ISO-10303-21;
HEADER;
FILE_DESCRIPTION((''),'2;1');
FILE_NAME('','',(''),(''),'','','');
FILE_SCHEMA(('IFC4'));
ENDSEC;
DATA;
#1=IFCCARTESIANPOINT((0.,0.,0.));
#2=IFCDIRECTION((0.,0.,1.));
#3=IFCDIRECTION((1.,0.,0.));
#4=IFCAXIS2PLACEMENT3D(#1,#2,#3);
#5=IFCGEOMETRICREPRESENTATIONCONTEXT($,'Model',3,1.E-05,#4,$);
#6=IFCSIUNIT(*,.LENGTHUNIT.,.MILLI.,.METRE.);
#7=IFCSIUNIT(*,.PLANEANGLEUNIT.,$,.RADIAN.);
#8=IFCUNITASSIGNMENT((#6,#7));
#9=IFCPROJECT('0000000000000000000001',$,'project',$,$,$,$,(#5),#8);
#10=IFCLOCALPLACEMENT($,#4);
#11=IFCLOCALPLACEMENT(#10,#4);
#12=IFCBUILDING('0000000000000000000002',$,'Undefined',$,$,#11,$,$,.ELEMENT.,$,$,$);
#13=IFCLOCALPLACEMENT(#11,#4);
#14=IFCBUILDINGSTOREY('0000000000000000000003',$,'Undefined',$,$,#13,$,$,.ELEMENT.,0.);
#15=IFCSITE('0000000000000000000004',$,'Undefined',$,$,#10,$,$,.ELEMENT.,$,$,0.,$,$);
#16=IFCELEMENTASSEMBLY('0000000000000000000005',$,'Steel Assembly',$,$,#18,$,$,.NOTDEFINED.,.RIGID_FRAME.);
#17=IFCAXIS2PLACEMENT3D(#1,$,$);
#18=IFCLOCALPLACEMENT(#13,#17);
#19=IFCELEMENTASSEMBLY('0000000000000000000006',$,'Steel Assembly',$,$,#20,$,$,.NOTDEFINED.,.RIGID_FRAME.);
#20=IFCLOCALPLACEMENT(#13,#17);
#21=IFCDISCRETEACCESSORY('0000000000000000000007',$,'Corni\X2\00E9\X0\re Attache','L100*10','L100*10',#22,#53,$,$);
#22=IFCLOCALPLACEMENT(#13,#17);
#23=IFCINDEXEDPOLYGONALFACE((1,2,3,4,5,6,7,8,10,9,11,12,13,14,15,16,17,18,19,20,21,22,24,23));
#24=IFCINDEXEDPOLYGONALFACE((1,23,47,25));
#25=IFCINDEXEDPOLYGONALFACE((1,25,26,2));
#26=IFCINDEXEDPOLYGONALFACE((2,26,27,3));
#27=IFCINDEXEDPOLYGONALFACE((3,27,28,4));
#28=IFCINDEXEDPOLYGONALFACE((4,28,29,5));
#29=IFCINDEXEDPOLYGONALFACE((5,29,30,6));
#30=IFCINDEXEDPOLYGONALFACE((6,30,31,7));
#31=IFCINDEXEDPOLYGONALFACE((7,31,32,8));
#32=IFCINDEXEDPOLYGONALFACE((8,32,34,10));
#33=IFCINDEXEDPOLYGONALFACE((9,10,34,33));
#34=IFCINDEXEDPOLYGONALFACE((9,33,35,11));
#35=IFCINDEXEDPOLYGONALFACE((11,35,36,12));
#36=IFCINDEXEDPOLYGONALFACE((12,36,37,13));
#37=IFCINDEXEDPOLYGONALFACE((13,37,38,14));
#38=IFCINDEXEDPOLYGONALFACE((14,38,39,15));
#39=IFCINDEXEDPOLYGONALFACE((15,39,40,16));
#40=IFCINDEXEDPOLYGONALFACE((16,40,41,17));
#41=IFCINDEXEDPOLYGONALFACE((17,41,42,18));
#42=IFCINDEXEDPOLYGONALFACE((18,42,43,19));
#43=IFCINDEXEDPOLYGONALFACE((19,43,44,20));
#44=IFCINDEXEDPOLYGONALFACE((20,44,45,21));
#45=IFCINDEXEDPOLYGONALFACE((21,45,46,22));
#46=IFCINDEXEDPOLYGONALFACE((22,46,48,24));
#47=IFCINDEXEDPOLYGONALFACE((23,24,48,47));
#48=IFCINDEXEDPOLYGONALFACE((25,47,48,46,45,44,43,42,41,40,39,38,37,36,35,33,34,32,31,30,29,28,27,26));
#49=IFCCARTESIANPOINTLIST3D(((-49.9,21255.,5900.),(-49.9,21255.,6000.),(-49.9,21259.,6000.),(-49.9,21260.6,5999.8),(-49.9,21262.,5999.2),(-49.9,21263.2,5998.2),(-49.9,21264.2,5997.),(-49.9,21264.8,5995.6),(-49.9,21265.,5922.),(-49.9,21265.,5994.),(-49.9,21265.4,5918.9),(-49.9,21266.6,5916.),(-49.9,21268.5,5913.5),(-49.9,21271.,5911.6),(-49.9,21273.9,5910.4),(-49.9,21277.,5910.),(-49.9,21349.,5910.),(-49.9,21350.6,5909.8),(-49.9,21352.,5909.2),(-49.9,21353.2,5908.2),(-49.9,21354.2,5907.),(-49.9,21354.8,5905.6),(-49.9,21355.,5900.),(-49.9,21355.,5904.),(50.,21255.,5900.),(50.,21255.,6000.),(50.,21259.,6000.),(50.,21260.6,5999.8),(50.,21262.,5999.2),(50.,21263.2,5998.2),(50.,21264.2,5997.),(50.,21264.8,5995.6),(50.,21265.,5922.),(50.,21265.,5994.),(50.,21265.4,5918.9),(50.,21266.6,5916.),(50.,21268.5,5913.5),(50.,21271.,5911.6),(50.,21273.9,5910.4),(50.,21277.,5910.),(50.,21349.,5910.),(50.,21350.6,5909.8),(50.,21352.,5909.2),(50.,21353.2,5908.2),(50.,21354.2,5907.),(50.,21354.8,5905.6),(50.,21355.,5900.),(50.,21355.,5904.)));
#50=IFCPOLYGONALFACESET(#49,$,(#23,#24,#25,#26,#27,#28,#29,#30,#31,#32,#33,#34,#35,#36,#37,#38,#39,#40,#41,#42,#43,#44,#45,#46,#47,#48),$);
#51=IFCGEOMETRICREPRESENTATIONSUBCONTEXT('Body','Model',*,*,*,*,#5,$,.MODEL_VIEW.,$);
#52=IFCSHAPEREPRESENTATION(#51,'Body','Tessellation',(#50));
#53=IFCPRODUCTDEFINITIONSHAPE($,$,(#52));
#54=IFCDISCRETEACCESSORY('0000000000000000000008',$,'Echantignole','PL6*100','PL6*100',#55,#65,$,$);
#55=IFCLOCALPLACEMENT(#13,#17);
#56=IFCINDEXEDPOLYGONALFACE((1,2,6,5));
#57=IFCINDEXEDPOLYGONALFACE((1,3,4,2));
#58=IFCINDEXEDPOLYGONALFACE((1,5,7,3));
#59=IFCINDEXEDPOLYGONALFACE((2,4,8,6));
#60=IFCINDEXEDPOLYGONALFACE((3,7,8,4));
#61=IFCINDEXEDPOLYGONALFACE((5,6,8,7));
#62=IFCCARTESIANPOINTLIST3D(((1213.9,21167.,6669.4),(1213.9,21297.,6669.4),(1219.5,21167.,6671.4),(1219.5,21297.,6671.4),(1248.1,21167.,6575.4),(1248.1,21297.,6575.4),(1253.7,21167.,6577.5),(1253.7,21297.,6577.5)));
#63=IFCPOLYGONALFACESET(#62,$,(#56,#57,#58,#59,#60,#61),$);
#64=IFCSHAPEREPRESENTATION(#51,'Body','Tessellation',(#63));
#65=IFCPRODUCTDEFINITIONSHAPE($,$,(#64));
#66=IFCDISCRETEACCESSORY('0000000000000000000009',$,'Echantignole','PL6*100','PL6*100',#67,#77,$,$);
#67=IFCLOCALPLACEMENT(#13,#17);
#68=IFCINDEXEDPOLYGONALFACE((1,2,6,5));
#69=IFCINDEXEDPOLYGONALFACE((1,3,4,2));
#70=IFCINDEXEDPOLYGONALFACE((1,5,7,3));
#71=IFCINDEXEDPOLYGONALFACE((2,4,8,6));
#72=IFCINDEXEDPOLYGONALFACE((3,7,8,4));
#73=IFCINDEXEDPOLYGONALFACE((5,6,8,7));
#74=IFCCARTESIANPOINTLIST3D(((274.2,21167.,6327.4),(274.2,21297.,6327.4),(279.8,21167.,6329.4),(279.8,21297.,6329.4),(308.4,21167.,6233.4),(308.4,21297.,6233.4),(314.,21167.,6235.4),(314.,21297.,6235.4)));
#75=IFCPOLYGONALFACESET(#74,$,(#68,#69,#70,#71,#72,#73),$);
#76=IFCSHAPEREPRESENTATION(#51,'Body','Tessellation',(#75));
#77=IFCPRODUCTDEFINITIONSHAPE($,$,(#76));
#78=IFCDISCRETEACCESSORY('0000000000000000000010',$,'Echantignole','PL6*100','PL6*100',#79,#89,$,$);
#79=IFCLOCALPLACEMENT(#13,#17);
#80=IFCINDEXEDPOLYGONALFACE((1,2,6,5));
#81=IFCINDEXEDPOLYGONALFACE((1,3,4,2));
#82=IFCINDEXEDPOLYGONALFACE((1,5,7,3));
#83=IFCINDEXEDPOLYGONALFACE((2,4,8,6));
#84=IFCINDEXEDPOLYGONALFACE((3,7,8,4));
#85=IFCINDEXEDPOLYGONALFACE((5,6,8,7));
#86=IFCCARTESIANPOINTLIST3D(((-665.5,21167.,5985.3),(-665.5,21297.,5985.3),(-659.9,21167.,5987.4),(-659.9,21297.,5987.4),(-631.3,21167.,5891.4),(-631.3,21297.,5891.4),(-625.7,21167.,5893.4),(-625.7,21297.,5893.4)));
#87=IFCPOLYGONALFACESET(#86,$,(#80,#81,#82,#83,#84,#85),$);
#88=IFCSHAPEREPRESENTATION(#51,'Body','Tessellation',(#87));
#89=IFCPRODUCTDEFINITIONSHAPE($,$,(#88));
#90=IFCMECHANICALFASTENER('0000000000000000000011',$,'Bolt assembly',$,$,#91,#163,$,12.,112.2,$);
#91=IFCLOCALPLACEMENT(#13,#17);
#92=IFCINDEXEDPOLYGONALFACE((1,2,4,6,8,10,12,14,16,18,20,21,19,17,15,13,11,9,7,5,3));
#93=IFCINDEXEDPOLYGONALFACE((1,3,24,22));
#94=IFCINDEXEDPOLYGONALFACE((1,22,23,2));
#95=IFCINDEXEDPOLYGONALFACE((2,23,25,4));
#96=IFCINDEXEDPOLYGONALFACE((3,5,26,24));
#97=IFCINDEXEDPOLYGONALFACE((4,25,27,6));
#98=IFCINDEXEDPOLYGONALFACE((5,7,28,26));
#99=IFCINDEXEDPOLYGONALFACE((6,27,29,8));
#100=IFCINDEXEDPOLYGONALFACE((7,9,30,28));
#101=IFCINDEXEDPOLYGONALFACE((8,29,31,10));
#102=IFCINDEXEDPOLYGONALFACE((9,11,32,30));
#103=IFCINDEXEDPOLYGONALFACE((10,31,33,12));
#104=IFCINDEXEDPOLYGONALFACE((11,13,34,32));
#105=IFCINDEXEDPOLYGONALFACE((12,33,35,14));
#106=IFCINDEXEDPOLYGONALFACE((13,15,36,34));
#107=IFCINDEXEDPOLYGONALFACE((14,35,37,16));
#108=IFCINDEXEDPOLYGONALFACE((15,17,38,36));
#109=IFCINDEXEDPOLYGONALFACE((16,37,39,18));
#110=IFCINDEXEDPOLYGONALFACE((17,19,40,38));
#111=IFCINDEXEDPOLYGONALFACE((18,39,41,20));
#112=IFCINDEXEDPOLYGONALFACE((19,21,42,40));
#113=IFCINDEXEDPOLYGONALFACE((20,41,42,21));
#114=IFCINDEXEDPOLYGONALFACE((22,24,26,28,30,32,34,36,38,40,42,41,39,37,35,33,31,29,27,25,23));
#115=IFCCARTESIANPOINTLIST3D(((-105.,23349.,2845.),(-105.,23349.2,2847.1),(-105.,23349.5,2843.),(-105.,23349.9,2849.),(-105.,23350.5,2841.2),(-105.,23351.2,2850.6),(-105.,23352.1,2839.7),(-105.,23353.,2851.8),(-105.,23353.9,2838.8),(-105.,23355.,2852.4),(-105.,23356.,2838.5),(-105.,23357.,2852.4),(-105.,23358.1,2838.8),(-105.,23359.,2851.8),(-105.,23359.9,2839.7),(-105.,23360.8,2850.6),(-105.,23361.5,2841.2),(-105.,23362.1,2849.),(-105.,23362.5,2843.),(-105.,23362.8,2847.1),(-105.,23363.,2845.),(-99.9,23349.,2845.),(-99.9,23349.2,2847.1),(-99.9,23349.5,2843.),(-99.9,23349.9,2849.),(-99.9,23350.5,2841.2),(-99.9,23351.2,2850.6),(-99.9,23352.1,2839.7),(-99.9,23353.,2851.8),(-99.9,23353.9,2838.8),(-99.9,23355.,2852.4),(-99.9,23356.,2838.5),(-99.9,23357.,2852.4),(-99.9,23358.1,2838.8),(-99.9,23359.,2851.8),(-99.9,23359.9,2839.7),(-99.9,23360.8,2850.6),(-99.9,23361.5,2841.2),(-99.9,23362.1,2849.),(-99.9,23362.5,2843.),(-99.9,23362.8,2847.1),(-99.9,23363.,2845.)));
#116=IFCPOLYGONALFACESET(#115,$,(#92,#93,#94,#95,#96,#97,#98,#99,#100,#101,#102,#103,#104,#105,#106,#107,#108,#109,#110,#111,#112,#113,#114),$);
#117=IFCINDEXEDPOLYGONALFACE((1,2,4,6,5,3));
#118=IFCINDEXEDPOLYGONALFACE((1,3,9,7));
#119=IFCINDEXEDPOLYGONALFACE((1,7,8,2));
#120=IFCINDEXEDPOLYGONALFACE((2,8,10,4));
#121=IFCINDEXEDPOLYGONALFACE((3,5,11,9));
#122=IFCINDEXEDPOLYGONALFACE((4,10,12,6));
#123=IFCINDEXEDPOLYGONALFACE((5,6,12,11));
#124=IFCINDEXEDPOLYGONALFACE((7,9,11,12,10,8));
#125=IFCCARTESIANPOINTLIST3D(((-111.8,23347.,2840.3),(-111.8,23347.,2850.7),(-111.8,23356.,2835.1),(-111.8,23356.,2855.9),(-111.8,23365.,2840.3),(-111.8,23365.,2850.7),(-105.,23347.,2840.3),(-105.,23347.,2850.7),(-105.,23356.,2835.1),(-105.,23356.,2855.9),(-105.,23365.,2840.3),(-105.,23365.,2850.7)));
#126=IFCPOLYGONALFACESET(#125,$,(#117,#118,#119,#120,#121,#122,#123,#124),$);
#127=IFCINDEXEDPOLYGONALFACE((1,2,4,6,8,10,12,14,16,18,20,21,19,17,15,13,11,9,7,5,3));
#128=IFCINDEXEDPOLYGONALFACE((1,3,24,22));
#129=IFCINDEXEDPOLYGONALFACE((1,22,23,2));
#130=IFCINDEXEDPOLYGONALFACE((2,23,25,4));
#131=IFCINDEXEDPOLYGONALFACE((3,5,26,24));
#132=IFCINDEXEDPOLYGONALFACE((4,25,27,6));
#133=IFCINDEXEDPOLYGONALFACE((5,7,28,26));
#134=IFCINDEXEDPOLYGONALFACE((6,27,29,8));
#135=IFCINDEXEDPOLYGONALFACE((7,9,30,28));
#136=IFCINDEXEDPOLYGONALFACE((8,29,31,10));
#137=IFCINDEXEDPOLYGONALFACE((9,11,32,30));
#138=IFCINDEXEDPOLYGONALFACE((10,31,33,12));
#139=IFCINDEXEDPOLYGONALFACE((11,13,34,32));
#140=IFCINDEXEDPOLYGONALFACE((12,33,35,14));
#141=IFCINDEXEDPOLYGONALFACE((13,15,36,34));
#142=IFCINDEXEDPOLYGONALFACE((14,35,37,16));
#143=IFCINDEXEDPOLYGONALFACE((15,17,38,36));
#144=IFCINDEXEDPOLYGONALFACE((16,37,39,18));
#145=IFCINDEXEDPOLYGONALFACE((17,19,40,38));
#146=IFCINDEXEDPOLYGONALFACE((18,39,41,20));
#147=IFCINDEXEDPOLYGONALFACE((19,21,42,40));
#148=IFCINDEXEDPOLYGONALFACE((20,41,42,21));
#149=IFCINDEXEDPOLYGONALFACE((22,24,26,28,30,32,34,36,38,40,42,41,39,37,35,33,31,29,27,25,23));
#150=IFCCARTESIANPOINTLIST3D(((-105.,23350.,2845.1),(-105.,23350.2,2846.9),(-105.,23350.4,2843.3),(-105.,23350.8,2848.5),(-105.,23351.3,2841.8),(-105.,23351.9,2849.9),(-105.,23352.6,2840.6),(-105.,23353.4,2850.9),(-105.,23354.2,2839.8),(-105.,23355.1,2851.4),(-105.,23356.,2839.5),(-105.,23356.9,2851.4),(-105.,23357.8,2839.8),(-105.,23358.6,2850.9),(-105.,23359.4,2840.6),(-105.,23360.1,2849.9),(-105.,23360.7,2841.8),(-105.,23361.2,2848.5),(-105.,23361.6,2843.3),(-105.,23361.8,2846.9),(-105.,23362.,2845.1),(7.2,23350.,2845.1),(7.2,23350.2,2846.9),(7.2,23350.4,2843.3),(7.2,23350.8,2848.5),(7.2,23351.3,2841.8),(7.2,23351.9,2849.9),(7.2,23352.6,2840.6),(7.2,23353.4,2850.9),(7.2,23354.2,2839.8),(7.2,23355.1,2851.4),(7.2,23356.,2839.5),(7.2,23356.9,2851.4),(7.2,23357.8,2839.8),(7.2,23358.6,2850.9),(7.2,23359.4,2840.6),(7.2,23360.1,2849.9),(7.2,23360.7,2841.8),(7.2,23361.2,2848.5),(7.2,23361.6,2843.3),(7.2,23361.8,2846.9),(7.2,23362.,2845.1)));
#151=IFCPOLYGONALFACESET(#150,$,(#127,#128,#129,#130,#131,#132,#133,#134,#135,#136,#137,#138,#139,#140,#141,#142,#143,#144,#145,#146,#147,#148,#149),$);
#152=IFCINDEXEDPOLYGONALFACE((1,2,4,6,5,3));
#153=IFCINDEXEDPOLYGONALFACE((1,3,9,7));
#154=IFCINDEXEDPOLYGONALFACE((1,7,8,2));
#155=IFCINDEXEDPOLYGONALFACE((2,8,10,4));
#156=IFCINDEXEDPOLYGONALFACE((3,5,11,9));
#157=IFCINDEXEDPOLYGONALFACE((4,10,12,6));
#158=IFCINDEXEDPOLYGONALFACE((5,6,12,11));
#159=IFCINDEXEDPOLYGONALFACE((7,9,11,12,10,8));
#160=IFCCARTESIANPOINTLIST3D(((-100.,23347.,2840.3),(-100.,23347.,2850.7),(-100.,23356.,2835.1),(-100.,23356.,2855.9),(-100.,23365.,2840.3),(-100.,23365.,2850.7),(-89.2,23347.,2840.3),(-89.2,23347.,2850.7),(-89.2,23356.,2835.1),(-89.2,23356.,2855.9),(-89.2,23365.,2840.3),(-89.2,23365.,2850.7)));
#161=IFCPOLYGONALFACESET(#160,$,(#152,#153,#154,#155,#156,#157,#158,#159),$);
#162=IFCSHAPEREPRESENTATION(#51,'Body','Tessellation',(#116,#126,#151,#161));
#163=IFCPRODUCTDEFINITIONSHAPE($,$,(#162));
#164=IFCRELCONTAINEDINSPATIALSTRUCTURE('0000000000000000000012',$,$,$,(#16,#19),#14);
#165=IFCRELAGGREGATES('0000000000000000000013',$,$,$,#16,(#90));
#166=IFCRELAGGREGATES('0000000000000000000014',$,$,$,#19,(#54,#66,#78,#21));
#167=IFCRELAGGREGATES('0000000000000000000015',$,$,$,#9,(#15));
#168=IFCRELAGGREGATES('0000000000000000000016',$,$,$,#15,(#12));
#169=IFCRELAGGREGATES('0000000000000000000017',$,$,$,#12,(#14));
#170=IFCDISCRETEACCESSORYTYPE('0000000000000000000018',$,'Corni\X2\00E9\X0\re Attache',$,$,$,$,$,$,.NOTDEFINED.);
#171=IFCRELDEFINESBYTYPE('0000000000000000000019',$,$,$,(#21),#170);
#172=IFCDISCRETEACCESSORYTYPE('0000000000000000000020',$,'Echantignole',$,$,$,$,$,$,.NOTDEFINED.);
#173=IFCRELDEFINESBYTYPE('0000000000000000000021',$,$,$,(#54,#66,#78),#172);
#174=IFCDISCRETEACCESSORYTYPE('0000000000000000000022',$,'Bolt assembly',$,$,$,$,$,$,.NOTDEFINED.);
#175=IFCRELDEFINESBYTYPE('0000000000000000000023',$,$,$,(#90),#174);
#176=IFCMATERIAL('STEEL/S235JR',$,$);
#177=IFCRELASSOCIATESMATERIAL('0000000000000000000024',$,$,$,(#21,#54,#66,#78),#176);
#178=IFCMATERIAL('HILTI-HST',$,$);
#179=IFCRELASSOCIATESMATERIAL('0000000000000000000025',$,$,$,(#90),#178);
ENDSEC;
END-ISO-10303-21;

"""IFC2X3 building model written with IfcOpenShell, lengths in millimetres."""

from ifc_helpers import new_model, si_unit, frame, origin_with_axes, origin_2d_with_axis, place, context, subcontext, project, spatial, polyline, circle, l_section, outline, extrude, source, transform, mapped, material, type_object, element, aggregate, save


model = new_model("IFC2X3")

# Units and contexts
model_context = context("Model", 3, precision=1e-05, world=origin_with_axes())
body_context = subcontext(model_context, "Body", "Model", "MODEL_VIEW")
ifc_project = project(units=[si_unit("LENGTHUNIT", "METRE", prefix="MILLI"), si_unit("PLANEANGLEUNIT", "RADIAN")], contexts=[model_context])

# Site, building, storey
site_placement = place(None, origin_with_axes())
site = spatial("IfcSite", under=ifc_project, at=site_placement, Name="Undefined", CompositionType="ELEMENT", RefElevation=0.0)
building_placement = place(site_placement, origin_with_axes())
building = spatial("IfcBuilding", under=site, at=building_placement, Name="Undefined", CompositionType="ELEMENT")
storey_placement = place(building_placement, origin_with_axes())
storey = spatial("IfcBuildingStorey", under=building, at=storey_placement, Name="Undefined", CompositionType="ELEMENT", Elevation=0.0)

# Element assemblies
assembly_1_placement = place(storey_placement, origin_with_axes())
assembly_1 = element("IfcElementAssembly", 1, at=assembly_1_placement, inside=storey, Name="Steel Assembly", AssemblyPlace="NOTDEFINED", PredefinedType="RIGID_FRAME")
ifc_material_1 = material(Name="STEEL/S235JR")
assembly_2_placement = place(storey_placement, origin_with_axes())
assembly_2 = element("IfcElementAssembly", 2, at=assembly_2_placement, inside=storey, Name="Steel Assembly", AssemblyPlace="NOTDEFINED", PredefinedType="RIGID_FRAME")

# Discrete accessories
discrete_accessory_type_1 = type_object("IfcDiscreteAccessoryType", Name="Corniére Attache")
discrete_accessory_1_placement = place(assembly_2_placement, frame((49.9, 21305.0, 5950.0), z_axis=(0.0, 0.0, 1.0), x_axis=(-1.0, 0.0, 0.0)))
discrete_accessory_1 = element("IfcDiscreteAccessory", 3, at=discrete_accessory_1_placement, type_object=discrete_accessory_type_1, material=ifc_material_1, Name="Corniére Attache", Description="L100*10", ObjectType="L100*10", context=body_context, shape_type="SweptSolid", body=[
    extrude(l_section(Depth=100.0, Width=100.0, Thickness=10.0, FilletRadius=12.0, EdgeRadius=6.0, at=origin_2d_with_axis()), frame((99.9, 0.0, 0.0), z_axis=(-1.0, 0.0, 0.0), x_axis=(0.0, -1.0, 0.0)), (0.0, 0.0, 1.0), 99.9),
])
discrete_accessory_type_2 = type_object("IfcDiscreteAccessoryType", Name="Echantignole")
discrete_accessory_2_placement = place(assembly_2_placement, frame((1233.8, 21297.0, 6623.4), z_axis=(-0.939693, 0.0, -0.34202), x_axis=(0.0, -1.0, 0.0)))
discrete_accessory_2 = element("IfcDiscreteAccessory", 4, at=discrete_accessory_2_placement, type_object=discrete_accessory_type_2, material=ifc_material_1, Name="Echantignole", Description="PL6*100", ObjectType="PL6*100", context=body_context, shape_type="SweptSolid", body=[
    extrude(outline(polyline([(130.0, -50.0), (0.0, -50.0), (0.0, 50.0), (130.0, 50.0), (130.0, -50.0)])), frame((0.0, 0.0, -3.0), z_axis=(0.0, 0.0, 1.0), x_axis=(1.0, 0.0, 0.0)), (0.0, 0.0, 1.0), 6.0),
])
discrete_accessory_3_placement = place(assembly_2_placement, frame((294.1, 21297.0, 6281.4), z_axis=(-0.939693, 0.0, -0.34202), x_axis=(0.0, -1.0, 0.0)))
discrete_accessory_3 = element("IfcDiscreteAccessory", 5, at=discrete_accessory_3_placement, type_object=discrete_accessory_type_2, material=ifc_material_1, Name="Echantignole", Description="PL6*100", ObjectType="PL6*100", context=body_context, shape_type="SweptSolid", body=[
    extrude(outline(polyline([(130.0, -50.0), (0.0, -50.0), (0.0, 50.0), (130.0, 50.0), (130.0, -50.0)])), frame((0.0, 0.0, -3.0), z_axis=(0.0, 0.0, 1.0), x_axis=(1.0, 0.0, 0.0)), (0.0, 0.0, 1.0), 6.0),
])
discrete_accessory_4_placement = place(assembly_2_placement, frame((-645.6, 21297.0, 5939.4), z_axis=(-0.939693, 0.0, -0.34202), x_axis=(0.0, -1.0, 0.0)))
discrete_accessory_4 = element("IfcDiscreteAccessory", 6, at=discrete_accessory_4_placement, type_object=discrete_accessory_type_2, material=ifc_material_1, Name="Echantignole", Description="PL6*100", ObjectType="PL6*100", context=body_context, shape_type="SweptSolid", body=[
    extrude(outline(polyline([(130.0, -50.0), (0.0, -50.0), (0.0, 50.0), (130.0, 50.0), (130.0, -50.0)])), frame((0.0, 0.0, -3.0), z_axis=(0.0, 0.0, 1.0), x_axis=(1.0, 0.0, 0.0)), (0.0, 0.0, 1.0), 6.0),
])

# Shared definitions
discrete_accessory_type_3 = type_object("IfcDiscreteAccessoryType", Name="Bolt assembly")

# Mechanical fastener
ifc_material_2 = material(Name="HILTI-HST")
shared_shape_1 = source(origin_with_axes(), body_context, "Body", "SweptSolid", [
    extrude(circle(Radius=7.0, at=origin_2d_with_axis()), frame((0.0, -5.0, 0.0), z_axis=(0.0, 1.0, 0.0), x_axis=(1.0, 0.0, 0.0)), (0.0, 0.0, 1.0), 5.1),
    extrude(outline(polyline([(10.4, 0.0), (5.2, 9.0), (-5.2, 9.0), (-10.4, 0.0), (-5.2, -9.0), (5.2, -9.0), (10.4, 0.0)])), frame((0.0, -11.8, 0.0), z_axis=(0.0, 1.0, 0.0), x_axis=(1.0, 0.0, 0.0)), (0.0, 0.0, 1.0), 6.8),
    extrude(circle(Radius=6.0, at=origin_2d_with_axis()), frame((0.0, -5.0, 0.0), z_axis=(0.0, 1.0, 0.0), x_axis=(1.0, 0.0, 0.0)), (0.0, 0.0, 1.0), 112.2),
    extrude(outline(polyline([(10.4, 0.0), (5.2, 9.0), (-5.2, 9.0), (-10.4, 0.0), (-5.2, -9.0), (5.2, -9.0), (10.4, 0.0)])), frame((0.0, 0.0, 0.0), z_axis=(0.0, 1.0, 0.0), x_axis=(1.0, 0.0, 0.0)), (0.0, 0.0, 1.0), 10.8),
])
mechanical_fastener_1_placement = place(assembly_1_placement, frame((-100.0, 23356.0, 2845.5), z_axis=(0.0, -1.0, 0.0), x_axis=(0.0, 0.0, -1.0)))
mechanical_fastener_1 = element("IfcMechanicalFastener", 7, at=mechanical_fastener_1_placement, type_object=discrete_accessory_type_3, material=ifc_material_2, Name="Bolt assembly", NominalDiameter=12.0, NominalLength=112.2, context=body_context, shape_type="MappedRepresentation", body=[
    mapped(shared_shape_1, transform((0.0, 0.0, 0.0))),
])
aggregate(assembly_1, [mechanical_fastener_1])

aggregate(assembly_2, [discrete_accessory_2, discrete_accessory_3, discrete_accessory_4, discrete_accessory_1])

save(model, "model.ifc")
